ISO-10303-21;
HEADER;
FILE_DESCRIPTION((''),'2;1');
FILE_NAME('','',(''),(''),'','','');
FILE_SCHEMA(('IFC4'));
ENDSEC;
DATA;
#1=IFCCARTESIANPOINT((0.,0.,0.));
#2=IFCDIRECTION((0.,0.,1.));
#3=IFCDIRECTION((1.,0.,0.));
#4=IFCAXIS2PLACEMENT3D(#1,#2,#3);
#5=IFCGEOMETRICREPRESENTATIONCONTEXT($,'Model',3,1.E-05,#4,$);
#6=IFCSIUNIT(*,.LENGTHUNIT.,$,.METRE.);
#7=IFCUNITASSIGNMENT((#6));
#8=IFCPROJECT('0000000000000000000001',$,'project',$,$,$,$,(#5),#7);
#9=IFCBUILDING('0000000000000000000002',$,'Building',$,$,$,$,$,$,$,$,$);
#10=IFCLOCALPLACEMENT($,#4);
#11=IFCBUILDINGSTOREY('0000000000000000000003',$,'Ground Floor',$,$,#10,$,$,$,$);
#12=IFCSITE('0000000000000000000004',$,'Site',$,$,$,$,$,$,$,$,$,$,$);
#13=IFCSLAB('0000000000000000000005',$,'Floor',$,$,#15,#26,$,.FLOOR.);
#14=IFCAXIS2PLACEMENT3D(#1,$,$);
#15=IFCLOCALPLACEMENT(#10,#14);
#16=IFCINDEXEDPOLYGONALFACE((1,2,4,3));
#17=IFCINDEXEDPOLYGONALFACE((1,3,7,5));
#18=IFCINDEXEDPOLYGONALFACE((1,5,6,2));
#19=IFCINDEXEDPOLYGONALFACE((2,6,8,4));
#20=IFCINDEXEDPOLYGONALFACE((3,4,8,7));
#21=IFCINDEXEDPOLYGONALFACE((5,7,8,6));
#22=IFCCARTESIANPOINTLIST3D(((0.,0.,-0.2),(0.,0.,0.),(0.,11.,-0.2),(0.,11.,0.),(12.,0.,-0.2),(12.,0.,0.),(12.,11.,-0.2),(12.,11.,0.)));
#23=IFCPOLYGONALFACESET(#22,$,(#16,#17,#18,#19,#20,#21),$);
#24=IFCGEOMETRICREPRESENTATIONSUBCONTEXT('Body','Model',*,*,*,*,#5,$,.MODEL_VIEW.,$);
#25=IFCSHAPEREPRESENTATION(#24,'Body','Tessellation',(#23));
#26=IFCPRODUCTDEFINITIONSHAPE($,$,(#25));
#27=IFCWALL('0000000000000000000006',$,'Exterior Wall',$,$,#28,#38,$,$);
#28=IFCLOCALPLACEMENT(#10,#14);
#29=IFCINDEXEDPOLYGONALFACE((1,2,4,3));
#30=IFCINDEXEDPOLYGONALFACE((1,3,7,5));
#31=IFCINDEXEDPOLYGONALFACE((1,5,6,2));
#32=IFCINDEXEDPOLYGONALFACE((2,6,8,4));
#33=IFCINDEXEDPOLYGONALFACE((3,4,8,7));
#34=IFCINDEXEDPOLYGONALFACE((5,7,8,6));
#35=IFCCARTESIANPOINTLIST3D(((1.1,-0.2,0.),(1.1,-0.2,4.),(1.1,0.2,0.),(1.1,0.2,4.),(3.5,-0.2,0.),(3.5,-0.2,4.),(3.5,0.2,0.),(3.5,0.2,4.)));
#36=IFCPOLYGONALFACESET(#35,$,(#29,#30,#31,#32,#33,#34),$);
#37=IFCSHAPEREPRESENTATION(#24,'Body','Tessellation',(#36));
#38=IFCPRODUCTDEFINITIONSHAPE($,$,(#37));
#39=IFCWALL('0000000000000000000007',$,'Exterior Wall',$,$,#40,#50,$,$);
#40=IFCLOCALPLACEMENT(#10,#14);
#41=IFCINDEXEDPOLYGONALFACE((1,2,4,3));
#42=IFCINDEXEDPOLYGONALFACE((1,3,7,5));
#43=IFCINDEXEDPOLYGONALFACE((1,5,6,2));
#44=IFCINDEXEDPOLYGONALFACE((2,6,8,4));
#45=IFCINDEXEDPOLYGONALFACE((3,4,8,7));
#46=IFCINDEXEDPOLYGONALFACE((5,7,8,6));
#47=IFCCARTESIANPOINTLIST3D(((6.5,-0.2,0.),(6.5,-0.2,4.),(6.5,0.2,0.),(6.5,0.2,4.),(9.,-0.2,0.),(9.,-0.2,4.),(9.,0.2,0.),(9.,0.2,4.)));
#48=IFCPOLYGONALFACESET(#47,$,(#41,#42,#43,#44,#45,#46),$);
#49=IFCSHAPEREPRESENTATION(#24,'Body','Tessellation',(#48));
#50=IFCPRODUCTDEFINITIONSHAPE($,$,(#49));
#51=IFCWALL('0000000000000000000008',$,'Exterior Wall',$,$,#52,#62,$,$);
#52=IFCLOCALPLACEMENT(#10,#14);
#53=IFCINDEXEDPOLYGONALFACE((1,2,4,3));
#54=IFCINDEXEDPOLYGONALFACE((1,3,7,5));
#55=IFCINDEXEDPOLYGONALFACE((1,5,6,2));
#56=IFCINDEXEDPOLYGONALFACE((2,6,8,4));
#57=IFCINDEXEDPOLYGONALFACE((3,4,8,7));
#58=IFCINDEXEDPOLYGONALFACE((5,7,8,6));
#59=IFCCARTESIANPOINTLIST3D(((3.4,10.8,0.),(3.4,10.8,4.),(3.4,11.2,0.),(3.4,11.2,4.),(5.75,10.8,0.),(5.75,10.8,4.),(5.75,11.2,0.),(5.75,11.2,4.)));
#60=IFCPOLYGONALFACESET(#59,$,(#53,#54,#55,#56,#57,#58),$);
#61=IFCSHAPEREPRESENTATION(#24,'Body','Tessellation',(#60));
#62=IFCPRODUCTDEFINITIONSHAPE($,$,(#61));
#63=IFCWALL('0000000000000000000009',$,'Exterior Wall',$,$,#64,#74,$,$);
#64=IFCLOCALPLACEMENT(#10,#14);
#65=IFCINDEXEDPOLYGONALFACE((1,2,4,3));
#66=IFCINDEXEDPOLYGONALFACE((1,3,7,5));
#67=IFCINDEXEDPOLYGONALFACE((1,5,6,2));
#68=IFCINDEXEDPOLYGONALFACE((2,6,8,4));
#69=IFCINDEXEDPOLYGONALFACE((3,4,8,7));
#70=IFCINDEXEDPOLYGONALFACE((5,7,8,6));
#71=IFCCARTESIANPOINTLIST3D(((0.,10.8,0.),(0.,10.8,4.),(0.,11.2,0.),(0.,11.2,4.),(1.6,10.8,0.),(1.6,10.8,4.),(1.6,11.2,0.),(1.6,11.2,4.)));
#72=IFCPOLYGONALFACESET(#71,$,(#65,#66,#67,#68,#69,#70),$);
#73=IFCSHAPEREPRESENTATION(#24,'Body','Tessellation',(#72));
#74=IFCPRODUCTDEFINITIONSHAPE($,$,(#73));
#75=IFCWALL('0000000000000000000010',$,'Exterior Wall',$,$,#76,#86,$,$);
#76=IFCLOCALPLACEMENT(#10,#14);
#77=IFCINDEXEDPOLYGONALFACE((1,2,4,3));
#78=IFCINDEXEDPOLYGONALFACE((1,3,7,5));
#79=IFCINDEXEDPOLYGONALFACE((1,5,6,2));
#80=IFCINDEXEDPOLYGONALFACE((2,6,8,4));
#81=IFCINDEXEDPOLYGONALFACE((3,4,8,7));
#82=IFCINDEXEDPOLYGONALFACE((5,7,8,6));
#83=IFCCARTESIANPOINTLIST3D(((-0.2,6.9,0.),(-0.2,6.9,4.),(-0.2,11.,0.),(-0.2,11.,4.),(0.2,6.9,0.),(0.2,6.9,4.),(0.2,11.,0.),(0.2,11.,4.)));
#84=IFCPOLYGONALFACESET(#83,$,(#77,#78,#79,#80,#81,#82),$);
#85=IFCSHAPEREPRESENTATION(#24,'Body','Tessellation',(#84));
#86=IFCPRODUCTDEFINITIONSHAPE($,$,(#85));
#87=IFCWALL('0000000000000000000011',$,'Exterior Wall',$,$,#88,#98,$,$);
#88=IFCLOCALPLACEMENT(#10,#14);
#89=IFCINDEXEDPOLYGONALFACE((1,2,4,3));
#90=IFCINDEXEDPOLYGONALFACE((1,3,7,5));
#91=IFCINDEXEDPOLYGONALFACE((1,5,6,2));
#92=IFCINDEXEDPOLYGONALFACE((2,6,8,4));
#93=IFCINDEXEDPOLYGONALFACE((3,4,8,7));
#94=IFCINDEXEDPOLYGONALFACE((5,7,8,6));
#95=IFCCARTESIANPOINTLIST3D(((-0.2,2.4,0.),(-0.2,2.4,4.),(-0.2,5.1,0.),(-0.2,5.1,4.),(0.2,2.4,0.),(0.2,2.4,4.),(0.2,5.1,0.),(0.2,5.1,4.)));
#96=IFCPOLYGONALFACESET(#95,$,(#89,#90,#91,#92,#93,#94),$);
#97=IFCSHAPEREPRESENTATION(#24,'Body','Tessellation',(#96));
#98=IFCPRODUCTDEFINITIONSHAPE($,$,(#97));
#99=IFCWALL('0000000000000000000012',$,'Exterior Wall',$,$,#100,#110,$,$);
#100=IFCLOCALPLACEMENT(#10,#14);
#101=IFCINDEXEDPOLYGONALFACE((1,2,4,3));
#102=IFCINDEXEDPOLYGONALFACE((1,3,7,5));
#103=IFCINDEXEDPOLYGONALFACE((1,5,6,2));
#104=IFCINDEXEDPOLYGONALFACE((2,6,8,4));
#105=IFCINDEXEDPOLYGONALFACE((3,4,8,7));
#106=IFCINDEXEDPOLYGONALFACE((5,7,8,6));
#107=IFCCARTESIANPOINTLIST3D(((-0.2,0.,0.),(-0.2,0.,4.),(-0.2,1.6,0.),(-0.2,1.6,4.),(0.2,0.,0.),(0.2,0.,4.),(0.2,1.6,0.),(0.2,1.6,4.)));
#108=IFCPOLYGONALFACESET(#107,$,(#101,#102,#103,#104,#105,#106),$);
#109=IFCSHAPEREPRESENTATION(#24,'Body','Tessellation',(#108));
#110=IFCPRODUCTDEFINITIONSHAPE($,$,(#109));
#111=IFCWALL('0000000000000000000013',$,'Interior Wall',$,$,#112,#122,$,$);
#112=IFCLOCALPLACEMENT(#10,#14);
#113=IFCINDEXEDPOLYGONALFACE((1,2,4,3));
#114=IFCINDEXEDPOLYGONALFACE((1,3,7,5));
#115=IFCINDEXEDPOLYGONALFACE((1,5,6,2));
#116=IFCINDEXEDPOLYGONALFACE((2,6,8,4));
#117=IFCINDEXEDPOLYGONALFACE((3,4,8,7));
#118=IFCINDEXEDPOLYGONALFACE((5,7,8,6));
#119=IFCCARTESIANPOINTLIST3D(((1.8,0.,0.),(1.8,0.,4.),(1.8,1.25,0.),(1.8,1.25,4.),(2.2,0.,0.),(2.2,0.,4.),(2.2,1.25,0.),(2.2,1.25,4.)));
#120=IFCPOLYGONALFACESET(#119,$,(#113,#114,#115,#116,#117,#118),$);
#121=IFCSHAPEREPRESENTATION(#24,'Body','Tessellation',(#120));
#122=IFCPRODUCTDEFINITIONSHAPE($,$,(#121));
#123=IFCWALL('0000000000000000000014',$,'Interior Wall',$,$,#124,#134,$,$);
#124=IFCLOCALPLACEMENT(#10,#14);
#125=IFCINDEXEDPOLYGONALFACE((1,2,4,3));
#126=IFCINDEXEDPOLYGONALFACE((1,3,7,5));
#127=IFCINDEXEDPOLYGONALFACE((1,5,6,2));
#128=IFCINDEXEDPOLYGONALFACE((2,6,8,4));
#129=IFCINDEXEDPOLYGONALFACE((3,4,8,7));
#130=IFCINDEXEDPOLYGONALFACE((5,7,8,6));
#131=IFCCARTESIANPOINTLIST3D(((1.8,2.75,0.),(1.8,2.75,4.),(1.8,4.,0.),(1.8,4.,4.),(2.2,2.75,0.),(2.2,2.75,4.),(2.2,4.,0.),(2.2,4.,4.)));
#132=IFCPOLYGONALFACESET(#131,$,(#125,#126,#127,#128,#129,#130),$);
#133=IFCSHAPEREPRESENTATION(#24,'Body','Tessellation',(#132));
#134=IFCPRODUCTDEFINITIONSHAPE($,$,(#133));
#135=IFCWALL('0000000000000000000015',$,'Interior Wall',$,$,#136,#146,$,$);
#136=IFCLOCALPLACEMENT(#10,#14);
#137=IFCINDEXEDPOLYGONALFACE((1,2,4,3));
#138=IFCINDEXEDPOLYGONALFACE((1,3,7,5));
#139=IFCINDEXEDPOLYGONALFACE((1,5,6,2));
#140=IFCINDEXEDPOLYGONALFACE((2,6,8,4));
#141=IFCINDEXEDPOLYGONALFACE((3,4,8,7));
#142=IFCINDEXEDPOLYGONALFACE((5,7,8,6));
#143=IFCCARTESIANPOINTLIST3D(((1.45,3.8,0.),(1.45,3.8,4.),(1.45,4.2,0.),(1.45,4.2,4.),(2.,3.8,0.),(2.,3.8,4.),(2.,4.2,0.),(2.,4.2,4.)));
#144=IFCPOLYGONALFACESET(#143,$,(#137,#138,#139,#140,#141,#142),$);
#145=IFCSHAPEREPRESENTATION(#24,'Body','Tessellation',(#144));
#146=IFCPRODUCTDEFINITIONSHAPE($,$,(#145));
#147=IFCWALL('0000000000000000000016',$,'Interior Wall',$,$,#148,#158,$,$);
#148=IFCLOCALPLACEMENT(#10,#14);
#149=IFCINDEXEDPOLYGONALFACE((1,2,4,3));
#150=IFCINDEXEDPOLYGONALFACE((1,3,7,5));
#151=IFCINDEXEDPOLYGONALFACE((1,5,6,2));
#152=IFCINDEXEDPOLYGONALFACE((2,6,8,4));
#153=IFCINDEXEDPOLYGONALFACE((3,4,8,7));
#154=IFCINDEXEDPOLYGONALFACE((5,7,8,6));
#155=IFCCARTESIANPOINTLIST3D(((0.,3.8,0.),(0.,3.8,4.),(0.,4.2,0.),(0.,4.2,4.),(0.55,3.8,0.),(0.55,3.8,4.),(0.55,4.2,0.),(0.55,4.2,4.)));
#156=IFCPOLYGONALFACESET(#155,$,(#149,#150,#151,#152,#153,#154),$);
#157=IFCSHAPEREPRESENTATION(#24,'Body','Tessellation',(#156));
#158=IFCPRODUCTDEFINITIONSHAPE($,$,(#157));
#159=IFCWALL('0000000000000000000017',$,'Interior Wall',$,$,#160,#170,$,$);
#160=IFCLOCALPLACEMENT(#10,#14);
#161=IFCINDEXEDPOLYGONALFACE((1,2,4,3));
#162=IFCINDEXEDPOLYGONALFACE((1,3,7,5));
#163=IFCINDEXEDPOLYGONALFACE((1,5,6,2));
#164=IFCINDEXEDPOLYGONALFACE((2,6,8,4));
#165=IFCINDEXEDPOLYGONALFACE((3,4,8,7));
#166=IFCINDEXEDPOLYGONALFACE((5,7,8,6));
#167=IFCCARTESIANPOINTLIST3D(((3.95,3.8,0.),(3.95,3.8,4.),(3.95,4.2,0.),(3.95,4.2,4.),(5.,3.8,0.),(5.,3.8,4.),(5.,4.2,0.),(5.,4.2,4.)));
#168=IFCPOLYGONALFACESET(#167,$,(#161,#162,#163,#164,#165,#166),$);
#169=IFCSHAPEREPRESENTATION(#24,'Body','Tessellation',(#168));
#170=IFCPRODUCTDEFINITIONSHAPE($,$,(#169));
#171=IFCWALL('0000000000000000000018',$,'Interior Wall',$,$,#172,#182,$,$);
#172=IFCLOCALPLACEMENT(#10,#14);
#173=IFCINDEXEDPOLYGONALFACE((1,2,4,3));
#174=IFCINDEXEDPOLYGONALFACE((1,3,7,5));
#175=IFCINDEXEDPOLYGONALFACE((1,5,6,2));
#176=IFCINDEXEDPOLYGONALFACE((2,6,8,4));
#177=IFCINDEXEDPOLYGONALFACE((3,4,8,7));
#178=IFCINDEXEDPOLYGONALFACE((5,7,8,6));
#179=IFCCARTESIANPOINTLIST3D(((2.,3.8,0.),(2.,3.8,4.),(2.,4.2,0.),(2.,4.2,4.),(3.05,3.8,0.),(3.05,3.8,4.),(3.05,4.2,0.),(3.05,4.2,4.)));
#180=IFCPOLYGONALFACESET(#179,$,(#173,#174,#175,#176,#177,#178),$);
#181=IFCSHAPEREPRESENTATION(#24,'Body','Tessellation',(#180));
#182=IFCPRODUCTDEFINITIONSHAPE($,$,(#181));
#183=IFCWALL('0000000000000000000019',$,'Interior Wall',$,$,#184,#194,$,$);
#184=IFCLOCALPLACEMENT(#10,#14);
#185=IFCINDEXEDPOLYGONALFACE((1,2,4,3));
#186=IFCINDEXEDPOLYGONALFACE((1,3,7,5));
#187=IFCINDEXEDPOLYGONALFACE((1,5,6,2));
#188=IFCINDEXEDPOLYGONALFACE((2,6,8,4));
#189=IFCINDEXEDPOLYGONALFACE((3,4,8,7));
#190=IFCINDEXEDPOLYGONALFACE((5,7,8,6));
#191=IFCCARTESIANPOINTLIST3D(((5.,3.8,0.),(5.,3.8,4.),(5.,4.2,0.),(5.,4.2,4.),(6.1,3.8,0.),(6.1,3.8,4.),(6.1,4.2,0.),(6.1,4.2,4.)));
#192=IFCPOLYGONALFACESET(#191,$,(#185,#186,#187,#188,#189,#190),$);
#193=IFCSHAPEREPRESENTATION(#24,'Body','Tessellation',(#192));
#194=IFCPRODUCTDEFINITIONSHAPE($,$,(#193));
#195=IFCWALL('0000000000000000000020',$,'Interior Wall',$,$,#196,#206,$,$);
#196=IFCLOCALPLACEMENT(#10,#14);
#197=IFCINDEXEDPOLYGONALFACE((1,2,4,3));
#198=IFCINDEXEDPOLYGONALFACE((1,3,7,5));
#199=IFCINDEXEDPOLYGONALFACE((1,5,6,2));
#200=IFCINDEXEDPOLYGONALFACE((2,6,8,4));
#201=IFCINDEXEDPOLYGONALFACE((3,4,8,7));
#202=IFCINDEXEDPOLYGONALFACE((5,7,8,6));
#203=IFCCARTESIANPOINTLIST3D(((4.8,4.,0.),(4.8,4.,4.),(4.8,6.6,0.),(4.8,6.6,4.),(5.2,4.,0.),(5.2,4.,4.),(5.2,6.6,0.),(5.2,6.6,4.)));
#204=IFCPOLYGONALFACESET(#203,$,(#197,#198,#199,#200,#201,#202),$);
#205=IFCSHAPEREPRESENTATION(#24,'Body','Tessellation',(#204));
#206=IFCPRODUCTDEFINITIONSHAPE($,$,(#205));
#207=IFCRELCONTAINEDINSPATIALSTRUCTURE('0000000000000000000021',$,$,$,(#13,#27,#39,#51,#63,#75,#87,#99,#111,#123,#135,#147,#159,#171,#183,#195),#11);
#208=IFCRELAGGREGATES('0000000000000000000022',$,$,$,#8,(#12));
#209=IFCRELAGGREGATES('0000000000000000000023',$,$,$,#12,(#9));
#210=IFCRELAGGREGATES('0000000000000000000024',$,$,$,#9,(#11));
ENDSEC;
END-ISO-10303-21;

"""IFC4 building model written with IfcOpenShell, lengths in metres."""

from ifc_helpers import new_model, si_unit, frame, origin_with_axes, place, context, subcontext, project, spatial, indexed_curve, outline, extrude, element, save


model = new_model("IFC4")

# Units and contexts
model_context = context("Model", 3, precision=1e-05, world=origin_with_axes())
body_context = subcontext(model_context, "Body", "Model", "MODEL_VIEW")
ifc_project = project(units=[si_unit("LENGTHUNIT", "METRE")], contexts=[model_context])

# Site, building, storey
site = spatial("IfcSite", under=ifc_project, Name="Site")
building = spatial("IfcBuilding", under=site, Name="Building")
storey_placement = place(None, origin_with_axes())
storey = spatial("IfcBuildingStorey", under=building, at=storey_placement, Name="Ground Floor")

# Slab
slab_placement = place(storey_placement, frame((0.0, 0.0, -0.2), z_axis=(0.0, 0.0, 1.0), x_axis=(1.0, 0.0, 0.0)))
element("IfcSlab", 1, at=slab_placement, inside=storey, Name="Floor", PredefinedType="FLOOR", context=body_context, shape_type="SweptSolid", body=[
    extrude(outline(indexed_curve([(0.0, 0.0), (12.0, 0.0), (12.0, 11.0), (0.0, 11.0)])), None, (0.0, 0.0, 1.0), 0.2),
])

# Walls
wall_1_placement = place(storey_placement, frame((1.1, 0.0, 0.0), z_axis=(0.0, 0.0, 1.0), x_axis=(1.0, 0.0, 0.0)))
element("IfcWall", 2, at=wall_1_placement, inside=storey, Name="Exterior Wall", context=body_context, shape_type="SweptSolid", body=[
    extrude(outline(indexed_curve([(0.0, 0.0), (0.0, 0.4), (2.4, 0.4), (2.4, 0.0), (0.0, 0.0)], self_intersect=False)), frame((0.0, -0.2, 0.0), z_axis=(0.0, 0.0, 1.0), x_axis=(1.0, 0.0, 0.0)), (0.0, 0.0, 1.0), 4.0),
])
wall_2_placement = place(storey_placement, frame((6.5, 0.0, 0.0), z_axis=(0.0, 0.0, 1.0), x_axis=(1.0, 0.0, 0.0)))
element("IfcWall", 3, at=wall_2_placement, inside=storey, Name="Exterior Wall", context=body_context, shape_type="SweptSolid", body=[
    extrude(outline(indexed_curve([(0.0, 0.0), (0.0, 0.4), (2.5, 0.4), (2.5, 0.0), (0.0, 0.0)], self_intersect=False)), frame((0.0, -0.2, 0.0), z_axis=(0.0, 0.0, 1.0), x_axis=(1.0, 0.0, 0.0)), (0.0, 0.0, 1.0), 4.0),
])
wall_3_placement = place(storey_placement, frame((5.75, 11.0, 0.0), z_axis=(0.0, 0.0, 1.0), x_axis=(-1.0, 0.0, 0.0)))
element("IfcWall", 4, at=wall_3_placement, inside=storey, Name="Exterior Wall", context=body_context, shape_type="SweptSolid", body=[
    extrude(outline(indexed_curve([(0.0, 0.0), (0.0, 0.4), (2.35, 0.4), (2.35, 0.0), (0.0, 0.0)], self_intersect=False)), frame((0.0, -0.2, 0.0), z_axis=(0.0, 0.0, 1.0), x_axis=(1.0, 0.0, 0.0)), (0.0, 0.0, 1.0), 4.0),
])
wall_4_placement = place(storey_placement, frame((1.6, 11.0, 0.0), z_axis=(0.0, 0.0, 1.0), x_axis=(-1.0, 0.0, 0.0)))
element("IfcWall", 5, at=wall_4_placement, inside=storey, Name="Exterior Wall", context=body_context, shape_type="SweptSolid", body=[
    extrude(outline(indexed_curve([(0.0, 0.0), (0.0, 0.4), (1.6, 0.4), (1.6, 0.0), (0.0, 0.0)], self_intersect=False)), frame((0.0, -0.2, 0.0), z_axis=(0.0, 0.0, 1.0), x_axis=(1.0, 0.0, 0.0)), (0.0, 0.0, 1.0), 4.0),
])
wall_5_placement = place(storey_placement, frame((0.0, 11.0, 0.0), z_axis=(0.0, 0.0, 1.0), x_axis=(0.0, -1.0, 0.0)))
element("IfcWall", 6, at=wall_5_placement, inside=storey, Name="Exterior Wall", context=body_context, shape_type="SweptSolid", body=[
    extrude(outline(indexed_curve([(0.0, 0.0), (0.0, 0.4), (4.1, 0.4), (4.1, 0.0), (0.0, 0.0)], self_intersect=False)), frame((0.0, -0.2, 0.0), z_axis=(0.0, 0.0, 1.0), x_axis=(1.0, 0.0, 0.0)), (0.0, 0.0, 1.0), 4.0),
])
wall_6_placement = place(storey_placement, frame((0.0, 5.1, 0.0), z_axis=(0.0, 0.0, 1.0), x_axis=(0.0, -1.0, 0.0)))
element("IfcWall", 7, at=wall_6_placement, inside=storey, Name="Exterior Wall", context=body_context, shape_type="SweptSolid", body=[
    extrude(outline(indexed_curve([(0.0, 0.0), (0.0, 0.4), (2.7, 0.4), (2.7, 0.0), (0.0, 0.0)], self_intersect=False)), frame((0.0, -0.2, 0.0), z_axis=(0.0, 0.0, 1.0), x_axis=(1.0, 0.0, 0.0)), (0.0, 0.0, 1.0), 4.0),
])
wall_7_placement = place(storey_placement, frame((0.0, 1.6, 0.0), z_axis=(0.0, 0.0, 1.0), x_axis=(0.0, -1.0, 0.0)))
element("IfcWall", 8, at=wall_7_placement, inside=storey, Name="Exterior Wall", context=body_context, shape_type="SweptSolid", body=[
    extrude(outline(indexed_curve([(0.0, 0.0), (0.0, 0.4), (1.6, 0.4), (1.6, 0.0), (0.0, 0.0)], self_intersect=False)), frame((0.0, -0.2, 0.0), z_axis=(0.0, 0.0, 1.0), x_axis=(1.0, 0.0, 0.0)), (0.0, 0.0, 1.0), 4.0),
])
for number, where, z_axis, x_axis, name in (
    (9, (2.0, 0.0, 0.0), (0.0, 0.0, 1.0), (0.0, 1.0, 0.0), "Interior Wall"),
    (10, (2.0, 2.75, 0.0), (0.0, 0.0, 1.0), (0.0, 1.0, 0.0), "Interior Wall"),
):
    element("IfcWall", number, at=place(storey_placement, frame(where, z_axis=z_axis, x_axis=x_axis)), inside=storey, Name=name, context=body_context, shape_type="SweptSolid", body=[
        extrude(outline(indexed_curve([(0.0, 0.0), (0.0, 0.4), (1.25, 0.4), (1.25, 0.0), (0.0, 0.0)], self_intersect=False)), frame((0.0, -0.2, 0.0), z_axis=(0.0, 0.0, 1.0), x_axis=(1.0, 0.0, 0.0)), (0.0, 0.0, 1.0), 4.0),
    ])
for number, where, z_axis, x_axis, name in (
    (11, (2.0, 4.0, 0.0), (0.0, 0.0, 1.0), (-1.0, 0.0, 0.0), "Interior Wall"),
    (12, (0.55, 4.0, 0.0), (0.0, 0.0, 1.0), (-1.0, 0.0, 0.0), "Interior Wall"),
):
    element("IfcWall", number, at=place(storey_placement, frame(where, z_axis=z_axis, x_axis=x_axis)), inside=storey, Name=name, context=body_context, shape_type="SweptSolid", body=[
        extrude(outline(indexed_curve([(0.0, 0.0), (0.0, 0.4), (0.55, 0.4), (0.55, 0.0), (0.0, 0.0)], self_intersect=False)), frame((0.0, -0.2, 0.0), z_axis=(0.0, 0.0, 1.0), x_axis=(1.0, 0.0, 0.0)), (0.0, 0.0, 1.0), 4.0),
    ])
for number, where, z_axis, x_axis, name in (
    (13, (5.0, 4.0, 0.0), (0.0, 0.0, 1.0), (-1.0, 0.0, 0.0), "Interior Wall"),
    (14, (3.05, 4.0, 0.0), (0.0, 0.0, 1.0), (-1.0, 0.0, 0.0), "Interior Wall"),
):
    element("IfcWall", number, at=place(storey_placement, frame(where, z_axis=z_axis, x_axis=x_axis)), inside=storey, Name=name, context=body_context, shape_type="SweptSolid", body=[
        extrude(outline(indexed_curve([(0.0, 0.0), (0.0, 0.4), (1.05, 0.4), (1.05, 0.0), (0.0, 0.0)], self_intersect=False)), frame((0.0, -0.2, 0.0), z_axis=(0.0, 0.0, 1.0), x_axis=(1.0, 0.0, 0.0)), (0.0, 0.0, 1.0), 4.0),
    ])
wall_8_placement = place(storey_placement, frame((6.1, 4.0, 0.0), z_axis=(0.0, 0.0, 1.0), x_axis=(-1.0, 0.0, 0.0)))
element("IfcWall", 15, at=wall_8_placement, inside=storey, Name="Interior Wall", context=body_context, shape_type="SweptSolid", body=[
    extrude(outline(indexed_curve([(0.0, 0.0), (0.0, 0.4), (1.1, 0.4), (1.1, 0.0), (0.0, 0.0)], self_intersect=False)), frame((0.0, -0.2, 0.0), z_axis=(0.0, 0.0, 1.0), x_axis=(1.0, 0.0, 0.0)), (0.0, 0.0, 1.0), 4.0),
])
wall_9_placement = place(storey_placement, frame((5.0, 4.0, 0.0), z_axis=(0.0, 0.0, 1.0), x_axis=(0.0, 1.0, 0.0)))
element("IfcWall", 16, at=wall_9_placement, inside=storey, Name="Interior Wall", context=body_context, shape_type="SweptSolid", body=[
    extrude(outline(indexed_curve([(0.0, 0.0), (0.0, 0.4), (2.6, 0.4), (2.6, 0.0), (0.0, 0.0)], self_intersect=False)), frame((0.0, -0.2, 0.0), z_axis=(0.0, 0.0, 1.0), x_axis=(1.0, 0.0, 0.0)), (0.0, 0.0, 1.0), 4.0),
])

save(model, "model.ifc")
